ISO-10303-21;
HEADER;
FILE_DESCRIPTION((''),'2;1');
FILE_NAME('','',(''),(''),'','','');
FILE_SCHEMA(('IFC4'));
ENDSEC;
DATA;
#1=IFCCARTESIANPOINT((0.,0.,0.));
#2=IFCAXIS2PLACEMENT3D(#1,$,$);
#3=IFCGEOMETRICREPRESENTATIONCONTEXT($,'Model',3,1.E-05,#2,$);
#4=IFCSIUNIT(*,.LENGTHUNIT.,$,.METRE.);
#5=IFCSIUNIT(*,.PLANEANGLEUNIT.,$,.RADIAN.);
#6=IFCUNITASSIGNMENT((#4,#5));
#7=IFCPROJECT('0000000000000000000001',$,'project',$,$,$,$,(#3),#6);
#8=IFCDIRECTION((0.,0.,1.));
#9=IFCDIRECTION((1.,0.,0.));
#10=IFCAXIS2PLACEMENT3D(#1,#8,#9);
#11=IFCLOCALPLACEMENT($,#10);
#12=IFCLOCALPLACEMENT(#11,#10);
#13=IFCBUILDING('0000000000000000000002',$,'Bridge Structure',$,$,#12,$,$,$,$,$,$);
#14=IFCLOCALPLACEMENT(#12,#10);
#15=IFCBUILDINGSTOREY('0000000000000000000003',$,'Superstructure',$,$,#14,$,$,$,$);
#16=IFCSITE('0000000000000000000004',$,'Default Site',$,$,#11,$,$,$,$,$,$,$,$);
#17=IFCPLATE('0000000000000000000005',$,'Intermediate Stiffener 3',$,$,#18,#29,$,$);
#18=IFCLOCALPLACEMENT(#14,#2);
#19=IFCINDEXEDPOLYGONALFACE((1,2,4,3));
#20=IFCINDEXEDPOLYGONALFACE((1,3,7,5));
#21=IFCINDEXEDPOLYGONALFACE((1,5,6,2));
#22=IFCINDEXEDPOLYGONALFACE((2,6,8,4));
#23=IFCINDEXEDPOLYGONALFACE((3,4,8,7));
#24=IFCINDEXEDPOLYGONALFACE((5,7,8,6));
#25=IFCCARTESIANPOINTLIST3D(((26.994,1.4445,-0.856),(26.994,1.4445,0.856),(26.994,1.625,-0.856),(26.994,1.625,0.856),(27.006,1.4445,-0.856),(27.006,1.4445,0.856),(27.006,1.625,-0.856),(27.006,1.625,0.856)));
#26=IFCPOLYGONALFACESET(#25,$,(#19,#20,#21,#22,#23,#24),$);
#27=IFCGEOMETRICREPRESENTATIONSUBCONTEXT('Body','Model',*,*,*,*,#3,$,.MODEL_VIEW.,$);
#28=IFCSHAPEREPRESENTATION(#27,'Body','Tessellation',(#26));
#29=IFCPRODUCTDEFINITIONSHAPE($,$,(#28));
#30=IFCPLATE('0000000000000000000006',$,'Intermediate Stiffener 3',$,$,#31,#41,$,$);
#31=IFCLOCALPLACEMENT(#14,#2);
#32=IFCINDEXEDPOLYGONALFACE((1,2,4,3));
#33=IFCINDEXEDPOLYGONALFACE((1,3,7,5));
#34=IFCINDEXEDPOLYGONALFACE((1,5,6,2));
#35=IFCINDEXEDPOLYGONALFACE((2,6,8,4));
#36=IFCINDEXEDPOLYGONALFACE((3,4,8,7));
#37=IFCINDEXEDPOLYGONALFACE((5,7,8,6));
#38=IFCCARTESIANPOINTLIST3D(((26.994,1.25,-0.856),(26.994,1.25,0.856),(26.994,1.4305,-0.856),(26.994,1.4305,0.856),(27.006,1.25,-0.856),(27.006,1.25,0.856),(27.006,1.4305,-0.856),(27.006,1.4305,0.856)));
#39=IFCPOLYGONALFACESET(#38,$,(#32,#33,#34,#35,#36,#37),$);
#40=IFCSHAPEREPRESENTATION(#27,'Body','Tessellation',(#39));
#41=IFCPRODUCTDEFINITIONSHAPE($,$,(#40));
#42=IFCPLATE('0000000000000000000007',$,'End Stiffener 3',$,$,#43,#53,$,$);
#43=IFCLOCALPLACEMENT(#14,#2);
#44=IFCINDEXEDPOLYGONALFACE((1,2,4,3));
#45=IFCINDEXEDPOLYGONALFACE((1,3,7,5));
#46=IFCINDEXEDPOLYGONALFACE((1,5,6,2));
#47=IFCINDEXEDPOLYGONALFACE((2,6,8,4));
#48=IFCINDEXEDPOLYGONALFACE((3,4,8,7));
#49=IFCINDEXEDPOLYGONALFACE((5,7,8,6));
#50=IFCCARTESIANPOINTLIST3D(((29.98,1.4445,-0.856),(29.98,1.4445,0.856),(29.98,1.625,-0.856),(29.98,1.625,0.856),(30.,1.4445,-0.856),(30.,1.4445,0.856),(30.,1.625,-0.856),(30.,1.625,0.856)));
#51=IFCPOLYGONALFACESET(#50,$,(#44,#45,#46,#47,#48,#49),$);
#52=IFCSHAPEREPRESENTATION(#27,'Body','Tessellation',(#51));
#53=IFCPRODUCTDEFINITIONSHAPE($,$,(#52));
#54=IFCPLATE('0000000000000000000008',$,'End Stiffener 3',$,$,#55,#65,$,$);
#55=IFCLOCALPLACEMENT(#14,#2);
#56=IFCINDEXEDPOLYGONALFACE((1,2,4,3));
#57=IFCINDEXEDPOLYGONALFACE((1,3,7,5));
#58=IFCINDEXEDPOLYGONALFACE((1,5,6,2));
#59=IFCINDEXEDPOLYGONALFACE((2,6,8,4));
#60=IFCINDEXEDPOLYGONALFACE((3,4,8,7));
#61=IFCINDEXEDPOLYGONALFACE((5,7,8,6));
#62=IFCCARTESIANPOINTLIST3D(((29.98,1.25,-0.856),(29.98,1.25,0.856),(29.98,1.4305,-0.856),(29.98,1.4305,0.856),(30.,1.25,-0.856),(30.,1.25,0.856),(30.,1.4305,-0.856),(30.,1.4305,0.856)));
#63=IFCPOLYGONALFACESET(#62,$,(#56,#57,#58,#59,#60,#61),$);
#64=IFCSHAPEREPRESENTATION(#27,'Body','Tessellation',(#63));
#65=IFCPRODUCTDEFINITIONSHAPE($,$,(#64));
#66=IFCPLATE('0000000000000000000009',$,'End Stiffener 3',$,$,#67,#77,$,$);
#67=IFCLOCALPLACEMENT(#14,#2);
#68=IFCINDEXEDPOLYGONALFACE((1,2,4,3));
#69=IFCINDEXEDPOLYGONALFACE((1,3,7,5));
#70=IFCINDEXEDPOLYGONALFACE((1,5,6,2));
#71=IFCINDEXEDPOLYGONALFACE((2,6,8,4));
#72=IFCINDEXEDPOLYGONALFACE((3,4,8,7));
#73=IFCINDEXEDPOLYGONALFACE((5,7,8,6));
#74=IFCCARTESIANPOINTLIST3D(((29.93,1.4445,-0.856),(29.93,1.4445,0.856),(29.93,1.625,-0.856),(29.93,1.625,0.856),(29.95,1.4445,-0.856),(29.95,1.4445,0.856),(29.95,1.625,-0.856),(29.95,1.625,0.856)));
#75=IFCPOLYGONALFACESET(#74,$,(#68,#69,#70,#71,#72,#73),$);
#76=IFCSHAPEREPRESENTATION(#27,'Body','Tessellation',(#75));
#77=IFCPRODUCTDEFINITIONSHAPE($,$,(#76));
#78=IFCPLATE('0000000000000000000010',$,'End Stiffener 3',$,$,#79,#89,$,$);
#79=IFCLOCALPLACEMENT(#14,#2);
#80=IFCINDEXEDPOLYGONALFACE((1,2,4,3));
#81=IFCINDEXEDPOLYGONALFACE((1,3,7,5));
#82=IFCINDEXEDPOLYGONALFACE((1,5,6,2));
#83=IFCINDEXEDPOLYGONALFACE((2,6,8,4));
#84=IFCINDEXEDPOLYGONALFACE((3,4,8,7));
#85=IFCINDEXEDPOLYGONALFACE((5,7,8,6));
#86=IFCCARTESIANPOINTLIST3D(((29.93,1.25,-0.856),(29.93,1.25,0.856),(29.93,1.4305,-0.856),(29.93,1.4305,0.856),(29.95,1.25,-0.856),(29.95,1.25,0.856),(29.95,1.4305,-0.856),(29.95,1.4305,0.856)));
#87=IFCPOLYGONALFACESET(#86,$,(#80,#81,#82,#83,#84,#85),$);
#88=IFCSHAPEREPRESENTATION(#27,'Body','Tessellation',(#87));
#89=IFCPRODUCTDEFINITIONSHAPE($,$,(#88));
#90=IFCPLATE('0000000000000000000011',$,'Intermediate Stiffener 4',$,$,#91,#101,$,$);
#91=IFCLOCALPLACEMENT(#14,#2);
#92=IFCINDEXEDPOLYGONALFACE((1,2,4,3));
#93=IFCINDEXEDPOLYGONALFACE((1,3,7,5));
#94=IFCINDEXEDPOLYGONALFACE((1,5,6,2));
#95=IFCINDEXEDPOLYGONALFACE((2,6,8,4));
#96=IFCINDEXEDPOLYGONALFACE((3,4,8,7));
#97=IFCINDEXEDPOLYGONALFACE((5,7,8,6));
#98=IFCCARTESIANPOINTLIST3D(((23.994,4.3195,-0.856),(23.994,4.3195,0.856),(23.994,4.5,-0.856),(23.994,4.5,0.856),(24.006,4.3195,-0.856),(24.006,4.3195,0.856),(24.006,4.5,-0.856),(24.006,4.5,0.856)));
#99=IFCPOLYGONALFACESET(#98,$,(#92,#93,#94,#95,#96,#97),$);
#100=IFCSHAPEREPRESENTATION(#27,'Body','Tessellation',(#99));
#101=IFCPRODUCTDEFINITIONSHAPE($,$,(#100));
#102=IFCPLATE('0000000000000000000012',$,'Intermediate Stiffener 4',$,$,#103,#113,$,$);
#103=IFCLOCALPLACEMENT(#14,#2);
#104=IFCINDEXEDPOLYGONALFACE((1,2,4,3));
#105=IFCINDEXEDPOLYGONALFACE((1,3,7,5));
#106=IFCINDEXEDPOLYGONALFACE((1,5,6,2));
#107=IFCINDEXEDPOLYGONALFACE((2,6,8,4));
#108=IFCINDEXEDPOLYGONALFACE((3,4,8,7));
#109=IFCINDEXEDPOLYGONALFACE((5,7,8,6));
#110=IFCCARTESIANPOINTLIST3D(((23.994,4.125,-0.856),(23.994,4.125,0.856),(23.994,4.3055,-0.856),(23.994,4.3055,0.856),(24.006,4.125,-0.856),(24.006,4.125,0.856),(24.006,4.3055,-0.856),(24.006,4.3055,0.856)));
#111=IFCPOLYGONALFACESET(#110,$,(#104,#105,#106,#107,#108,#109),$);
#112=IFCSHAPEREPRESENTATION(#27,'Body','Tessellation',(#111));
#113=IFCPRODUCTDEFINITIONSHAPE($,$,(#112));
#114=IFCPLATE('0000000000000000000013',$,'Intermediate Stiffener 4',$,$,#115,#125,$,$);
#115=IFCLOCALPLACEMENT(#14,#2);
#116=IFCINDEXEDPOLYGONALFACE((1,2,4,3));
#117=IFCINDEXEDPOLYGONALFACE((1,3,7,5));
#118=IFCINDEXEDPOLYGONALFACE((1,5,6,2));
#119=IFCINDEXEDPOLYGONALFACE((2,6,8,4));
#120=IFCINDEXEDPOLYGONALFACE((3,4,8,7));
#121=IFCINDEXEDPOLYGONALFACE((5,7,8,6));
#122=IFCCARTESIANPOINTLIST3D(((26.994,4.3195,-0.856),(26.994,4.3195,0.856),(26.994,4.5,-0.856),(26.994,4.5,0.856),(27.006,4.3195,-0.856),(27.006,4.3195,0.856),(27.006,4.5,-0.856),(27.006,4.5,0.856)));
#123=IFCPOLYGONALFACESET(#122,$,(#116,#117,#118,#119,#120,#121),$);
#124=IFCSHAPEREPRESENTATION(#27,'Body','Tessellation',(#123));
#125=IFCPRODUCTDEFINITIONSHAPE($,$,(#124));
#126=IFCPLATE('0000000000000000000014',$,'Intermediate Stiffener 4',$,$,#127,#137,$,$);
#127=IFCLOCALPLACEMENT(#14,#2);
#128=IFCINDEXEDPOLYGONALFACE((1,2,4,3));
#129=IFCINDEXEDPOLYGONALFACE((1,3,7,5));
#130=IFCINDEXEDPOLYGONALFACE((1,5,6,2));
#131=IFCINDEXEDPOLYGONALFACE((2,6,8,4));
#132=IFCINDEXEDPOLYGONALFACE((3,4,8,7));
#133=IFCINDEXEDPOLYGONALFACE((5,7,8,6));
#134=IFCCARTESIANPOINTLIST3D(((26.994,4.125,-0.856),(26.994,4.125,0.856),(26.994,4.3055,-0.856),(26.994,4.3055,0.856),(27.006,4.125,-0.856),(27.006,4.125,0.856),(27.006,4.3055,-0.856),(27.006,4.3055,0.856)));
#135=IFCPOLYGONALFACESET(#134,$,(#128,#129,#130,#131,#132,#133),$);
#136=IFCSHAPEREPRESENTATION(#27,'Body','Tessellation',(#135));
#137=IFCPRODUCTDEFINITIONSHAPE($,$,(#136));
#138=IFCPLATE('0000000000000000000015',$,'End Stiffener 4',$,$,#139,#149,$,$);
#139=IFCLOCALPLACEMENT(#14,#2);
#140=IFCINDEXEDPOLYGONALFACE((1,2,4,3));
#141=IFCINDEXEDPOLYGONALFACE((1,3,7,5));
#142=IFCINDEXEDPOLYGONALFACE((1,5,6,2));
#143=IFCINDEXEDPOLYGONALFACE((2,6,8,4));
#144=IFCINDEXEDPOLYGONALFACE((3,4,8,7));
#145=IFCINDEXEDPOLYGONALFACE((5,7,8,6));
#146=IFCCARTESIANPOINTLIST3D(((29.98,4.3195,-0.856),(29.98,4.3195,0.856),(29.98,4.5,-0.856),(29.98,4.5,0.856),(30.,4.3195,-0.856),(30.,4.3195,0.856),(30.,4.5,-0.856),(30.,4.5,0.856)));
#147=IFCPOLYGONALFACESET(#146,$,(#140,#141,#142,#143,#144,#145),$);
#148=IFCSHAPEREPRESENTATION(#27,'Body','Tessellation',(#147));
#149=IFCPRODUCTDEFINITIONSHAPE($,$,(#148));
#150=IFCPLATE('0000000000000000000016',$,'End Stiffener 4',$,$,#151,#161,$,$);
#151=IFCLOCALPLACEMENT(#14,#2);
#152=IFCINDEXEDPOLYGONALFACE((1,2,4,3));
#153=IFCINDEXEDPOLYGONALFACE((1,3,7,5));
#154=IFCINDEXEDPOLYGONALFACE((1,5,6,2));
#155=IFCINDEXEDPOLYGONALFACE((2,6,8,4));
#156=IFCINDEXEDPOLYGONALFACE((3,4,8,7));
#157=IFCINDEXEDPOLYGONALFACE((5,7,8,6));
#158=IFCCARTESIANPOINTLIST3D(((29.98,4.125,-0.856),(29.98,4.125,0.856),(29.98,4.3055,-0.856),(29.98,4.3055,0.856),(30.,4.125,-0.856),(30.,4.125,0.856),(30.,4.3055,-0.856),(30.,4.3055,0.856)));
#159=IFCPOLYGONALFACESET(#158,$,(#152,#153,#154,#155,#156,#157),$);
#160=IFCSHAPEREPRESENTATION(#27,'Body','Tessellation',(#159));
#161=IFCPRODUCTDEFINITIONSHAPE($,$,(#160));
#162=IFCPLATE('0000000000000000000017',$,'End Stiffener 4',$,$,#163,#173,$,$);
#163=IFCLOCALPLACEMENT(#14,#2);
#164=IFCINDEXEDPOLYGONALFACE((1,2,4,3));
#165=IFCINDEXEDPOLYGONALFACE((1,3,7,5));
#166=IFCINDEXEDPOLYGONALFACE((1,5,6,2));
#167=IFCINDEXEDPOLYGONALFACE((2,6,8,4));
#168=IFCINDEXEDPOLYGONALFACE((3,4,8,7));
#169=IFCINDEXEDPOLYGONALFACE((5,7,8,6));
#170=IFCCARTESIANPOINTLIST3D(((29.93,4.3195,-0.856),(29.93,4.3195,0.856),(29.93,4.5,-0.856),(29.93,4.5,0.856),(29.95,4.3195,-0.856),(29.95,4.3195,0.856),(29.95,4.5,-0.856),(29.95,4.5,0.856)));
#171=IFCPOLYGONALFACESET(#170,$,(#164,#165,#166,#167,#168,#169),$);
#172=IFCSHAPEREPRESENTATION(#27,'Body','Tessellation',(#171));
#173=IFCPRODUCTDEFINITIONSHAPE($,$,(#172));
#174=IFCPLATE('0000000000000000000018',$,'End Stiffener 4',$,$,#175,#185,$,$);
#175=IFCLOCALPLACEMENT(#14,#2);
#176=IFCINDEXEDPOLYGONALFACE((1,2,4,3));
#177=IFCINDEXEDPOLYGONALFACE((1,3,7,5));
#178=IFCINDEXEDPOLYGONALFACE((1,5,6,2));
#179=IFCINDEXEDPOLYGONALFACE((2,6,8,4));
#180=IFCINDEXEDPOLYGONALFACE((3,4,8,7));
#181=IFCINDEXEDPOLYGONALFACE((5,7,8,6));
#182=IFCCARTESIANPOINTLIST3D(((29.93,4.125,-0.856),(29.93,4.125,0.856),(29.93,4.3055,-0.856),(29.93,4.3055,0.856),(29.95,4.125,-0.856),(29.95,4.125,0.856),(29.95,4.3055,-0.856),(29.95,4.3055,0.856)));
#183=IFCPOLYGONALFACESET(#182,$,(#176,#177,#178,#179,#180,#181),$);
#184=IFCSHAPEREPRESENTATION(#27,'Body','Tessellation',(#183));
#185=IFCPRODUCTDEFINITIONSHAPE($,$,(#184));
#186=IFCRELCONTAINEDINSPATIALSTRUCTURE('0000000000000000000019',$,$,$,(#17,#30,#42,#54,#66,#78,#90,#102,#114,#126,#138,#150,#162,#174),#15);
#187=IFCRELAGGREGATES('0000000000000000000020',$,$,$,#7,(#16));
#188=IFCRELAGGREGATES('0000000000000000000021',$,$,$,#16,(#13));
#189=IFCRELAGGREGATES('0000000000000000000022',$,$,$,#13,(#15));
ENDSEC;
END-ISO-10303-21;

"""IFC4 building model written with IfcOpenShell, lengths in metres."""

from ifc_helpers import new_model, si_unit, frame, origin, origin_with_axes, origin_2d_with_axis, place, context, subcontext, project, spatial, rectangle, extrude, element, save


model = new_model("IFC4")

# Units and contexts
model_context = context("Model", 3, precision=1e-05, world=origin())
body_context = subcontext(model_context, "Body", "Model", "MODEL_VIEW")
ifc_project = project(units=[si_unit("LENGTHUNIT", "METRE"), si_unit("PLANEANGLEUNIT", "RADIAN")], contexts=[model_context])

# Site, building, storey
site_placement = place(None, origin_with_axes())
site = spatial("IfcSite", under=ifc_project, at=site_placement, Name="Default Site")
building_placement = place(site_placement, origin_with_axes())
building = spatial("IfcBuilding", under=site, at=building_placement, Name="Bridge Structure")
storey_placement = place(building_placement, origin_with_axes())
storey = spatial("IfcBuildingStorey", under=building, at=storey_placement, Name="Superstructure")

# Plates
for number, where, z_axis, x_axis, name in (
    (1, (27.0, 1.5348, -0.856), (0.0, 0.0, 1.0), (1.0, 0.0, 0.0), "Intermediate Stiffener 3"),
    (2, (27.0, 1.3402, -0.856), (0.0, 0.0, 1.0), (1.0, 0.0, 0.0), "Intermediate Stiffener 3"),
):
    element("IfcPlate", number, at=place(storey_placement, frame(where, z_axis=z_axis, x_axis=x_axis)), inside=storey, Name=name, context=body_context, shape_type="SweptSolid", body=[
        extrude(rectangle(XDim=0.012, YDim=0.1805, at=origin_2d_with_axis()), origin_with_axes(), (0.0, 0.0, 1.0), 1.712),
    ])
for number, where, z_axis, x_axis, name in (
    (3, (29.99, 1.5348, -0.856), (0.0, 0.0, 1.0), (1.0, 0.0, 0.0), "End Stiffener 3"),
    (4, (29.99, 1.3402, -0.856), (0.0, 0.0, 1.0), (1.0, 0.0, 0.0), "End Stiffener 3"),
    (5, (29.94, 1.5348, -0.856), (0.0, 0.0, 1.0), (1.0, 0.0, 0.0), "End Stiffener 3"),
    (6, (29.94, 1.3402, -0.856), (0.0, 0.0, 1.0), (1.0, 0.0, 0.0), "End Stiffener 3"),
):
    element("IfcPlate", number, at=place(storey_placement, frame(where, z_axis=z_axis, x_axis=x_axis)), inside=storey, Name=name, context=body_context, shape_type="SweptSolid", body=[
        extrude(rectangle(XDim=0.02, YDim=0.1805, at=origin_2d_with_axis()), origin_with_axes(), (0.0, 0.0, 1.0), 1.712),
    ])
for number, where, z_axis, x_axis, name in (
    (7, (24.0, 4.4097, -0.856), (0.0, 0.0, 1.0), (1.0, 0.0, 0.0), "Intermediate Stiffener 4"),
    (8, (24.0, 4.2153, -0.856), (0.0, 0.0, 1.0), (1.0, 0.0, 0.0), "Intermediate Stiffener 4"),
    (9, (27.0, 4.4097, -0.856), (0.0, 0.0, 1.0), (1.0, 0.0, 0.0), "Intermediate Stiffener 4"),
    (10, (27.0, 4.2153, -0.856), (0.0, 0.0, 1.0), (1.0, 0.0, 0.0), "Intermediate Stiffener 4"),
):
    element("IfcPlate", number, at=place(storey_placement, frame(where, z_axis=z_axis, x_axis=x_axis)), inside=storey, Name=name, context=body_context, shape_type="SweptSolid", body=[
        extrude(rectangle(XDim=0.012, YDim=0.1805, at=origin_2d_with_axis()), origin_with_axes(), (0.0, 0.0, 1.0), 1.712),
    ])
for number, where, z_axis, x_axis, name in (
    (11, (29.99, 4.4097, -0.856), (0.0, 0.0, 1.0), (1.0, 0.0, 0.0), "End Stiffener 4"),
    (12, (29.99, 4.2153, -0.856), (0.0, 0.0, 1.0), (1.0, 0.0, 0.0), "End Stiffener 4"),
    (13, (29.94, 4.4097, -0.856), (0.0, 0.0, 1.0), (1.0, 0.0, 0.0), "End Stiffener 4"),
    (14, (29.94, 4.2153, -0.856), (0.0, 0.0, 1.0), (1.0, 0.0, 0.0), "End Stiffener 4"),
):
    element("IfcPlate", number, at=place(storey_placement, frame(where, z_axis=z_axis, x_axis=x_axis)), inside=storey, Name=name, context=body_context, shape_type="SweptSolid", body=[
        extrude(rectangle(XDim=0.02, YDim=0.1805, at=origin_2d_with_axis()), origin_with_axes(), (0.0, 0.0, 1.0), 1.712),
    ])

save(model, "model.ifc")
